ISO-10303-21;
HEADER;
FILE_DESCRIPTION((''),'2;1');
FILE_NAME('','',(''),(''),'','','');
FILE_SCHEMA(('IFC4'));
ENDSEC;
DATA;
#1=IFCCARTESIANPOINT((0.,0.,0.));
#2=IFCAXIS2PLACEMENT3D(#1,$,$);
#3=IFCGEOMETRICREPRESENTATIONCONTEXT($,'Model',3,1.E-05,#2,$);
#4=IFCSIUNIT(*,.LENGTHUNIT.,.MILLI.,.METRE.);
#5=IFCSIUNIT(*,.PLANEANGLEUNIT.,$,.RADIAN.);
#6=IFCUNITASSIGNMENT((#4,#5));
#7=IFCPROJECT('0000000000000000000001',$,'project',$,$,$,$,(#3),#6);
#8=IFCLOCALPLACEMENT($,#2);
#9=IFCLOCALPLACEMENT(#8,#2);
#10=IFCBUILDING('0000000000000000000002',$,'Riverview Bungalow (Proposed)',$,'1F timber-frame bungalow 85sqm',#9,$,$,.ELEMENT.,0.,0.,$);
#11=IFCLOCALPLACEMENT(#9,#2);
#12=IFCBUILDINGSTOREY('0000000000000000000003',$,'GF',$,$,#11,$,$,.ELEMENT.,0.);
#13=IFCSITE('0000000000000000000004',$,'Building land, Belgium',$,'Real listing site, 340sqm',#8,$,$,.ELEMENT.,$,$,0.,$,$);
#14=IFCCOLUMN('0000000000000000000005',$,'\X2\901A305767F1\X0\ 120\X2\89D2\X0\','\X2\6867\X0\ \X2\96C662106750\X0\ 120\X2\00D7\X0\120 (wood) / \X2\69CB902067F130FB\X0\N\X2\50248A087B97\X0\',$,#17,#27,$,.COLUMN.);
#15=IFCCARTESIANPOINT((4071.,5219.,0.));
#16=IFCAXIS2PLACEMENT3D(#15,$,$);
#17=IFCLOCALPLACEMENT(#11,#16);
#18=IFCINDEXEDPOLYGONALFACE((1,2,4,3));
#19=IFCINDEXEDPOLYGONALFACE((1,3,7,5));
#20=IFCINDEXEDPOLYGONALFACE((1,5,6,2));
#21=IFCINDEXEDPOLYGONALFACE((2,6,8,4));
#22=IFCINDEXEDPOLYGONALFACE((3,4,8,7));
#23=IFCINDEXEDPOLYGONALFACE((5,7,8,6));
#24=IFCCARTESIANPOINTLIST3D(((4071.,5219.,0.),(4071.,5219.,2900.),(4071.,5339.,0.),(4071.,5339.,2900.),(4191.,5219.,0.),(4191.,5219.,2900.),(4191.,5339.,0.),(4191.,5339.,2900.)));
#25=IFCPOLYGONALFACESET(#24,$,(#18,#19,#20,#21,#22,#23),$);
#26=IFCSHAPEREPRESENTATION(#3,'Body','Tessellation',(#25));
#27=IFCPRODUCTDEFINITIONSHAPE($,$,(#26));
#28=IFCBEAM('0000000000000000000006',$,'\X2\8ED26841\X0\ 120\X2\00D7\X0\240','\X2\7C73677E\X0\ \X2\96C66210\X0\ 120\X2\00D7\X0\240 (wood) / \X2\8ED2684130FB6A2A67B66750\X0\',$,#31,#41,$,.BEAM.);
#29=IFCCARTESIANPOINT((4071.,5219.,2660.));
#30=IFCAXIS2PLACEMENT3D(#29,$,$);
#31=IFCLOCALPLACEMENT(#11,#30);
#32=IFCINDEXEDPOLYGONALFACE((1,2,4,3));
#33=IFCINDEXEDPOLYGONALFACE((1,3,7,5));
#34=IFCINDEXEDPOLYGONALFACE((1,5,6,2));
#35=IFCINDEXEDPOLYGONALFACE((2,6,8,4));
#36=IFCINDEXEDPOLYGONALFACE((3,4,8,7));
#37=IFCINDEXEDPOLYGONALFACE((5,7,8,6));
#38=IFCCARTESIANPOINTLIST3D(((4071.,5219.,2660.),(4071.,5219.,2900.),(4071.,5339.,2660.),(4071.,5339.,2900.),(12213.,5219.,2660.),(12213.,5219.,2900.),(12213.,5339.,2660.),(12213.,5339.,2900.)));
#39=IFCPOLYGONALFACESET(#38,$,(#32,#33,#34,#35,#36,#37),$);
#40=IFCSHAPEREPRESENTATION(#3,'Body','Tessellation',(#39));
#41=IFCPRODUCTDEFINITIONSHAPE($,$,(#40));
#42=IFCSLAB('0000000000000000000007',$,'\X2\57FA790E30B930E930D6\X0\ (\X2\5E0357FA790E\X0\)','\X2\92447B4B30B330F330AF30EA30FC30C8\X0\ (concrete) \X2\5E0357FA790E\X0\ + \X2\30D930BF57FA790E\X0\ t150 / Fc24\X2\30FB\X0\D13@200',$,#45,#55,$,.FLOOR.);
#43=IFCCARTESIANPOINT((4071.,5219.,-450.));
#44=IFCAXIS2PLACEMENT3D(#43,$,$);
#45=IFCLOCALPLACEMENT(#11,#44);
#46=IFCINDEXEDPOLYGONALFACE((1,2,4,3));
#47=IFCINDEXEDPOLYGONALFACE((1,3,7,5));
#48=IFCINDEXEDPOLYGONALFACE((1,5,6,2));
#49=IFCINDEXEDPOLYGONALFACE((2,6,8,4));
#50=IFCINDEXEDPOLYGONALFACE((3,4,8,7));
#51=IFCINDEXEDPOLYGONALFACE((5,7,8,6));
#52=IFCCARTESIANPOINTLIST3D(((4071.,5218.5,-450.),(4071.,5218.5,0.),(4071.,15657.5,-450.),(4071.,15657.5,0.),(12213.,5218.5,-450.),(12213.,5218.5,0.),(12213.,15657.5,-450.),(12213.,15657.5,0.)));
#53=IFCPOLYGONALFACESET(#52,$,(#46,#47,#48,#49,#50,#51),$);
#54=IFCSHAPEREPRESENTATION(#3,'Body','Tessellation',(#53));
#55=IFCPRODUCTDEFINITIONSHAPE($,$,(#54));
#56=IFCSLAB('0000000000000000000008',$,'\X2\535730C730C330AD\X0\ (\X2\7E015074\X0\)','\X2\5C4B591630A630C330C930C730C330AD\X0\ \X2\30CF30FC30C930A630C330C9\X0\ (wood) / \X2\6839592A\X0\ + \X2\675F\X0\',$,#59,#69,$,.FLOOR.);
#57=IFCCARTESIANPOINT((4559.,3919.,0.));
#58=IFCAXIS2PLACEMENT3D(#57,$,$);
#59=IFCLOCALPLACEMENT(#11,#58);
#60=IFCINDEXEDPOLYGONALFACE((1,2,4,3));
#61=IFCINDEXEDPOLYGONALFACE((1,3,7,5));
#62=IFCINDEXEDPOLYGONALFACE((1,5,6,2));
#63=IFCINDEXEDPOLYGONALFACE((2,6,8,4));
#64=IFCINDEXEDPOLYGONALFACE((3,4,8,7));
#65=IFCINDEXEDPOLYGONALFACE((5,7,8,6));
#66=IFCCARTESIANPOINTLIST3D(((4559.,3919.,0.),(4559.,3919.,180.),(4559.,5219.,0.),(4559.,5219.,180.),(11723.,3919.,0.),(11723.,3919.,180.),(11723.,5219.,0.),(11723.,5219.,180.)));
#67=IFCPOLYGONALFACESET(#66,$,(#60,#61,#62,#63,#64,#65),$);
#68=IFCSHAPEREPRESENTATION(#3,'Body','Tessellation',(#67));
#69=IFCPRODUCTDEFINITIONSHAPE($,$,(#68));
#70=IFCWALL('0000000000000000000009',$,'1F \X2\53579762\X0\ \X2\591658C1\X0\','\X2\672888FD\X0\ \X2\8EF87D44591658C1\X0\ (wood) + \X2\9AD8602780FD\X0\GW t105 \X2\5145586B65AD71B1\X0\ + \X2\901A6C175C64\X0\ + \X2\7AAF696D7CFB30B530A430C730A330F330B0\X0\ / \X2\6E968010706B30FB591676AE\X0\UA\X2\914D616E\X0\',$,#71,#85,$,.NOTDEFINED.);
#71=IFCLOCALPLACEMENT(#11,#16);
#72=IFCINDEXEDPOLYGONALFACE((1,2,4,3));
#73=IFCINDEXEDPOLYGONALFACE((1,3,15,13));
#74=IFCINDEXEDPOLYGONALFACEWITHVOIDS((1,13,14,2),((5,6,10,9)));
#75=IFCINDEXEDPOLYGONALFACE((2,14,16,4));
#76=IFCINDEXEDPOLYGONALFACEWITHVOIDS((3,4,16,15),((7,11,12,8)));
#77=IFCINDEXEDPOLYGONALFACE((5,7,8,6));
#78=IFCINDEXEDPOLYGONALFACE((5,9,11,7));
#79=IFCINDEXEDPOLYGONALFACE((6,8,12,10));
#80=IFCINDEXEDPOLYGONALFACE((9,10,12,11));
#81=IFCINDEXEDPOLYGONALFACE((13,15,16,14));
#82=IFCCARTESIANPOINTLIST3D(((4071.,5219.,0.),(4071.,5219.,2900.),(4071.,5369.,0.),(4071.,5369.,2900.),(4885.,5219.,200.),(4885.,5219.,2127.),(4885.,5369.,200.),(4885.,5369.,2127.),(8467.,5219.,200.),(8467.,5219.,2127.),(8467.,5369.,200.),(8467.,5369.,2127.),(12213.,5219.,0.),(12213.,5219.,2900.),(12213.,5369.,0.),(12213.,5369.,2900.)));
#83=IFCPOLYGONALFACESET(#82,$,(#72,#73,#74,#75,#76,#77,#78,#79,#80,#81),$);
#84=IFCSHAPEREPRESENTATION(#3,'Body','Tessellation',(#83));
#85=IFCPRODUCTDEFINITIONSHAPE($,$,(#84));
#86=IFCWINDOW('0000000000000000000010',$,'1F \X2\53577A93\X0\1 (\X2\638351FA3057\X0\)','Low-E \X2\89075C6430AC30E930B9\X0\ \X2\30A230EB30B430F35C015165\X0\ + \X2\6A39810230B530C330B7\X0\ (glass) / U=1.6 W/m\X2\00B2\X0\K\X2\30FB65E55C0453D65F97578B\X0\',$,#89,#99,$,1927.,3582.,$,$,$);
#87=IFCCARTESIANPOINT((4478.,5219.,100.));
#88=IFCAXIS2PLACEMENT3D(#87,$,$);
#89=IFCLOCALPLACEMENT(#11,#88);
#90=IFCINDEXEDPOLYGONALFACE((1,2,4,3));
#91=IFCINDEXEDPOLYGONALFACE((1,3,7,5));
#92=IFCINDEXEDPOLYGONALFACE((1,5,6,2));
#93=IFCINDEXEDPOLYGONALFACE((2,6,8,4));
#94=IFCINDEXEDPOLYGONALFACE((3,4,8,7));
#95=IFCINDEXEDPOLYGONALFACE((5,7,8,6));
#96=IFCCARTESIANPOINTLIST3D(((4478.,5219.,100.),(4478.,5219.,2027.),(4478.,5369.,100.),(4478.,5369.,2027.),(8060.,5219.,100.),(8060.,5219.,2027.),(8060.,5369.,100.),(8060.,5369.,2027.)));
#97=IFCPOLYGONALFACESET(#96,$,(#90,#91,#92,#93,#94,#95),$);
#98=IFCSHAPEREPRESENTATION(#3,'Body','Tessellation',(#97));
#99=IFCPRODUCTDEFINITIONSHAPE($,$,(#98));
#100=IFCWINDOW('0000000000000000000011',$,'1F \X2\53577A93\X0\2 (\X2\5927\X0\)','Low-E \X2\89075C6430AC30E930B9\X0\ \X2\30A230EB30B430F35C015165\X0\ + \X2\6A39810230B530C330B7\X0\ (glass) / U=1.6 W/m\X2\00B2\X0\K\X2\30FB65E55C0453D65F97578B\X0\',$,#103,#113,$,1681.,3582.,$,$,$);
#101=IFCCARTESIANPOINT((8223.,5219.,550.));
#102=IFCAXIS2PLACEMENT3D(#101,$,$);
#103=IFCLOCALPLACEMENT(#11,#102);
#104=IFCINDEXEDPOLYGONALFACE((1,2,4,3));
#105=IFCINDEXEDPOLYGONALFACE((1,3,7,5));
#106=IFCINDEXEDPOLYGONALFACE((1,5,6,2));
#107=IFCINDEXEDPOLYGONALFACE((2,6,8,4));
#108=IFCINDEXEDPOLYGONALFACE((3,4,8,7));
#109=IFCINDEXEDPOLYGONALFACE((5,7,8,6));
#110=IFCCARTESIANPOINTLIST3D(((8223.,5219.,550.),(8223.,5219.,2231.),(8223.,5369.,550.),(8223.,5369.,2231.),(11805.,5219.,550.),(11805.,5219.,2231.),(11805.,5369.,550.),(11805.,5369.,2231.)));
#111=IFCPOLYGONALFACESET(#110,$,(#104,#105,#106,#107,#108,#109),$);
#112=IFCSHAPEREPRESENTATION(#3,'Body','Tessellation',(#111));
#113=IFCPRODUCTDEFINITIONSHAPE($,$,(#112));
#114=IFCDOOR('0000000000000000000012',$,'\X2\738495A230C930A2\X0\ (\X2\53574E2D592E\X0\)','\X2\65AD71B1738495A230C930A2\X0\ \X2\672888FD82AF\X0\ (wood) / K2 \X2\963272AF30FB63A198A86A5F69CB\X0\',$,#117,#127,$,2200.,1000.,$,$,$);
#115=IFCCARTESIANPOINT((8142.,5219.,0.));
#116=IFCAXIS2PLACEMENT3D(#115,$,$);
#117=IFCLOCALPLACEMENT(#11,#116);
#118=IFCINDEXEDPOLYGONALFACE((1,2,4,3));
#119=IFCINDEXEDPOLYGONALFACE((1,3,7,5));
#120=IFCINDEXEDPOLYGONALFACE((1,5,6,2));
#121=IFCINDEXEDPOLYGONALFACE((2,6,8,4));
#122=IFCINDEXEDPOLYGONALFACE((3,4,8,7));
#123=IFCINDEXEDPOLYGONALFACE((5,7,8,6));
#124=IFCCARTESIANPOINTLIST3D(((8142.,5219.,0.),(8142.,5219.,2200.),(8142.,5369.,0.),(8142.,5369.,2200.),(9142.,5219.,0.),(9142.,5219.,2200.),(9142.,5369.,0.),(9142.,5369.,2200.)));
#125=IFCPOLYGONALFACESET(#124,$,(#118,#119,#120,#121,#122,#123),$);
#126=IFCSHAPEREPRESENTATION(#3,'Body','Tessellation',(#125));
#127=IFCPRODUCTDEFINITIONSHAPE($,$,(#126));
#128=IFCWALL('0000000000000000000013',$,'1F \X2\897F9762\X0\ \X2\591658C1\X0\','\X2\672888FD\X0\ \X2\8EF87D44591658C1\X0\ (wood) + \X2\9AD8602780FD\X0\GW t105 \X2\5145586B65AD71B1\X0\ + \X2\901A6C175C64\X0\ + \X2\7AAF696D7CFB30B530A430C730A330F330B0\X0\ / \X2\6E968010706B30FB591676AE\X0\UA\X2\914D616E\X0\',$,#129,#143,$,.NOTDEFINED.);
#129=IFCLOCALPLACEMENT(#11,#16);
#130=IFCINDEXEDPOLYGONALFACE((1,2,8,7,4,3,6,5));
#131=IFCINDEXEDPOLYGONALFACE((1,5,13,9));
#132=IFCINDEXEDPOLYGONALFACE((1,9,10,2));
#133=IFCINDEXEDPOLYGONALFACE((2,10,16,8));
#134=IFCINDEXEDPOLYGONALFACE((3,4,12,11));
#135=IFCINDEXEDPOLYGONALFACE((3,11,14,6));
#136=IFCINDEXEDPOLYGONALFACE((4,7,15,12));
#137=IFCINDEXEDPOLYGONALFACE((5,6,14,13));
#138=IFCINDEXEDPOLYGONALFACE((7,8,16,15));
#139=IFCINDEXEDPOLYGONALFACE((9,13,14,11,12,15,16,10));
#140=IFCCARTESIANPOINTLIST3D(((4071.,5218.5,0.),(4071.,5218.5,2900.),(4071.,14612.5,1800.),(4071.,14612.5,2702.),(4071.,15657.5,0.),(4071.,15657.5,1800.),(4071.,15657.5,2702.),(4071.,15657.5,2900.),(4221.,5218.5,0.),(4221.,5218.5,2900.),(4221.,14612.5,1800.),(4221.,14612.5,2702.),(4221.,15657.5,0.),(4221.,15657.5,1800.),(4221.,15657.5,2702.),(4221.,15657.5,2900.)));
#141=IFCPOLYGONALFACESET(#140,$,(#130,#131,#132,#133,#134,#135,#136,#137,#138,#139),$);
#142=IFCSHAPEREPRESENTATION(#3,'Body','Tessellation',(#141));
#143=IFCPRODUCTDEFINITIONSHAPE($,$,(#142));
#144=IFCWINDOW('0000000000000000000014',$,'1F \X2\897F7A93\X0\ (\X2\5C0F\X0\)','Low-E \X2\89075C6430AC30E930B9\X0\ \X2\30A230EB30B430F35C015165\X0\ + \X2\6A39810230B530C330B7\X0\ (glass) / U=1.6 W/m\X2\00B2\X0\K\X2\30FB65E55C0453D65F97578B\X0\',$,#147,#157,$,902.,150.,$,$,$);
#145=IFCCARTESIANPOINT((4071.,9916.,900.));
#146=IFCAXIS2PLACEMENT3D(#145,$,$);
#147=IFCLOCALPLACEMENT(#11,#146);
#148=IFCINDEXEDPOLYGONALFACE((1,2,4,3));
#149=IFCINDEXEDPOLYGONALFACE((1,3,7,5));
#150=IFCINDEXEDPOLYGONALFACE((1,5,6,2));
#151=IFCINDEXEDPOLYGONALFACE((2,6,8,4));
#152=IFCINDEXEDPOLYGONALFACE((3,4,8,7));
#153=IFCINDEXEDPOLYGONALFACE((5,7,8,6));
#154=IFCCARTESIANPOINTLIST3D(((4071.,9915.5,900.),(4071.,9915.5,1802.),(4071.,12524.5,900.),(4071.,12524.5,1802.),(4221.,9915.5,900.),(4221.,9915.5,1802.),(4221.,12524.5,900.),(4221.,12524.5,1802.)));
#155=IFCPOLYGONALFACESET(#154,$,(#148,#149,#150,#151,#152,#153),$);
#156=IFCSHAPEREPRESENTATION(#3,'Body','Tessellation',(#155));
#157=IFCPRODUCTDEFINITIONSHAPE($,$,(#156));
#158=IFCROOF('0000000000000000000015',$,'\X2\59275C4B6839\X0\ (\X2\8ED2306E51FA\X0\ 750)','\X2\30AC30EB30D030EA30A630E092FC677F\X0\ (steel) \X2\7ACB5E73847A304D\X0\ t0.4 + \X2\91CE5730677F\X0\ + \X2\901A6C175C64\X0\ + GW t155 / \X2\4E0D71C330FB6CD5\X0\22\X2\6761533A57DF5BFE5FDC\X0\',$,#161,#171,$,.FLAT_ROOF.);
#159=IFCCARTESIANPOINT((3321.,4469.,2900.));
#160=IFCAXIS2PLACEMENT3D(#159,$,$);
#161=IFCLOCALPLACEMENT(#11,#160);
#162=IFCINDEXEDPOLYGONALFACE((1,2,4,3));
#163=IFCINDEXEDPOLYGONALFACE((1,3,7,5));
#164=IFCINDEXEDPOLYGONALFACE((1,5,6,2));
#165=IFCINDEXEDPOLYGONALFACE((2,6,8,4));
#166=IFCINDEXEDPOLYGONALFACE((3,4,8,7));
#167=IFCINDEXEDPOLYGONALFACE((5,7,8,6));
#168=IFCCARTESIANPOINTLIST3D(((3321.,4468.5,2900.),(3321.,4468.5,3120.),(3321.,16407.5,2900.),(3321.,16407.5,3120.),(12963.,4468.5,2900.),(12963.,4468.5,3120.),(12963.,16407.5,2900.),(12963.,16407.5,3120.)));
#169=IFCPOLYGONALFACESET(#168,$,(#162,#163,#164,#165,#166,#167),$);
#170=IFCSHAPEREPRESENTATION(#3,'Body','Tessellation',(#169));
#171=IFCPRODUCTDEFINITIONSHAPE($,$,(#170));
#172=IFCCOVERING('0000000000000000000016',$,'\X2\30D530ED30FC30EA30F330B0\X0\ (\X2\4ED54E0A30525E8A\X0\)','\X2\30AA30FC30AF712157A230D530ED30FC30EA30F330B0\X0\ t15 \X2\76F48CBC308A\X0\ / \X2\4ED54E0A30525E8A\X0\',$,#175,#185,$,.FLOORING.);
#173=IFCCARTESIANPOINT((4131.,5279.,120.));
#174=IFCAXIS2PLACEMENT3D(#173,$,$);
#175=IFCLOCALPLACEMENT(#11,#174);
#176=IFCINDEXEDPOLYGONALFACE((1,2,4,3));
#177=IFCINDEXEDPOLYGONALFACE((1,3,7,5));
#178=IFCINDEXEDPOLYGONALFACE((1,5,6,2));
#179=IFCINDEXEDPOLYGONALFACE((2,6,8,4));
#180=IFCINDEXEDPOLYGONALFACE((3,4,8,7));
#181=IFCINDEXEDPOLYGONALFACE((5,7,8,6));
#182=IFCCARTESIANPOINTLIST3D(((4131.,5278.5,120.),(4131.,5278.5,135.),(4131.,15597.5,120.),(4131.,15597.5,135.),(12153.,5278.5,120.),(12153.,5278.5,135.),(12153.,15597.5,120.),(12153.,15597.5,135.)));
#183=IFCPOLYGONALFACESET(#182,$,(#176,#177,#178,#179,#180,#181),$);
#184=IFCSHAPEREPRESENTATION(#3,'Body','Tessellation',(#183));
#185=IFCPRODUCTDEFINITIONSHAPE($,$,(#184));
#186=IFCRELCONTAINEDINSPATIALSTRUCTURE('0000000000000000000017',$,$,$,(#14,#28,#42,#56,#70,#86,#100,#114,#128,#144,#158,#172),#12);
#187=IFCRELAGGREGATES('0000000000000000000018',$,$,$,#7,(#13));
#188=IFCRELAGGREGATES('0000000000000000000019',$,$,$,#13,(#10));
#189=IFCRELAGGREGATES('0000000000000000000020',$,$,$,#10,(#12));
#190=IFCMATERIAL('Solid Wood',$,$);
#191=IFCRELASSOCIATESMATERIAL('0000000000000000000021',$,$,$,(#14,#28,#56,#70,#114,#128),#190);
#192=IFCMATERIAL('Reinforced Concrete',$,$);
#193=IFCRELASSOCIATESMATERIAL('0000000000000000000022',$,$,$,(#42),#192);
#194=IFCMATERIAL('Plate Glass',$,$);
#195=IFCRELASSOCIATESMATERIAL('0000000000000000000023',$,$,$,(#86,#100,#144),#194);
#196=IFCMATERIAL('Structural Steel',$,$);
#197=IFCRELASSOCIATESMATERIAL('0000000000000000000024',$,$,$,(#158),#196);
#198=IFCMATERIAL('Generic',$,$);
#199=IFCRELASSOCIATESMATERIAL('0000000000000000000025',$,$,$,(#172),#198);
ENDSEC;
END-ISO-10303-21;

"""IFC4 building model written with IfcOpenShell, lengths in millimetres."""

from ifc_helpers import new_model, si_unit, frame, frame_2d, origin, place, context, project, spatial, rectangle, extrude, material, element, fill, save


model = new_model("IFC4")

# Units and contexts
model_context = context("Model", 3, precision=1e-05, world=origin())
ifc_project = project(units=[si_unit("LENGTHUNIT", "METRE", prefix="MILLI"), si_unit("PLANEANGLEUNIT", "RADIAN")], contexts=[model_context])

# Site, building, storey
site_placement = place(None, origin())
site = spatial("IfcSite", under=ifc_project, at=site_placement, Name="Building land, Belgium", ObjectType="Real listing site, 340sqm", CompositionType="ELEMENT", RefElevation=0.0)
building_placement = place(site_placement, origin())
building = spatial("IfcBuilding", under=site, at=building_placement, Name="Riverview Bungalow (Proposed)", ObjectType="1F timber-frame bungalow 85sqm", CompositionType="ELEMENT", ElevationOfRefHeight=0.0, ElevationOfTerrain=0.0)
storey_placement = place(building_placement, origin())
storey = spatial("IfcBuildingStorey", under=building, at=storey_placement, Name="GF", CompositionType="ELEMENT", Elevation=0.0)

# Column
ifc_material_1 = material(Name="Solid Wood")
column_1_placement = place(storey_placement, frame((4071.0, 5219.0, 0.0)))
element("IfcColumn", 1, at=column_1_placement, inside=storey, material=ifc_material_1, Name="通し柱 120角", Description="桧 集成材 120×120 (wood) / 構造柱・N値計算", PredefinedType="COLUMN", context=model_context, shape_type="SweptSolid", body=[
    extrude(rectangle(XDim=120.0, YDim=120.0, at=frame_2d((60.0, 60.0))), frame((4071.0, 5219.0, 0.0)), (0.0, 0.0, 1.0), 2900.0),
])

# Beam
beam_1_placement = place(storey_placement, frame((4071.0, 5219.0, 2660.0)))
element("IfcBeam", 2, at=beam_1_placement, inside=storey, material=ifc_material_1, Name="軒桁 120×240", Description="米松 集成 120×240 (wood) / 軒桁・横架材", PredefinedType="BEAM", context=model_context, shape_type="SweptSolid", body=[
    extrude(rectangle(XDim=8142.0, YDim=120.0, at=frame_2d((4071.0, 60.0))), frame((4071.0, 5219.0, 2660.0)), (0.0, 0.0, 1.0), 240.0),
])

# Slabs
ifc_material_2 = material(Name="Reinforced Concrete")
slab_1_placement = place(storey_placement, frame((4071.0, 5219.0, -450.0)))
element("IfcSlab", 3, at=slab_1_placement, inside=storey, material=ifc_material_2, Name="基礎スラブ (布基礎)", Description="鉄筋コンクリート (concrete) 布基礎 + ベタ基礎 t150 / Fc24・D13@200", PredefinedType="FLOOR", context=model_context, shape_type="SweptSolid", body=[
    extrude(rectangle(XDim=8142.0, YDim=10439.0, at=frame_2d((4071.0, 5219.0))), frame((4071.0, 5219.0, -450.0)), (0.0, 0.0, 1.0), 450.0),
])
slab_2_placement = place(storey_placement, frame((4559.0, 3919.0, 0.0)))
element("IfcSlab", 4, at=slab_2_placement, inside=storey, material=ifc_material_1, Name="南デッキ (縁側)", Description="屋外ウッドデッキ ハードウッド (wood) / 根太 + 束", PredefinedType="FLOOR", context=model_context, shape_type="SweptSolid", body=[
    extrude(rectangle(XDim=7164.0, YDim=1300.0, at=frame_2d((3582.0, 650.0))), frame((4559.0, 3919.0, 0.0)), (0.0, 0.0, 1.0), 180.0),
])

# Wall, openings, windows, door
wall_1_placement = place(storey_placement, frame((4071.0, 5219.0, 0.0)))
wall_1 = element("IfcWall", 5, at=wall_1_placement, inside=storey, material=ifc_material_1, Name="1F 南面 外壁", Description="木製 軸組外壁 (wood) + 高性能GW t105 充填断熱 + 通気層 + 窯業系サイディング / 準耐火・外皮UA配慮", PredefinedType="NOTDEFINED", context=model_context, shape_type="SweptSolid", body=[
    extrude(rectangle(XDim=8142.0, YDim=150.0, at=frame_2d((4071.0, 75.0))), frame((4071.0, 5219.0, 0.0)), (0.0, 0.0, 1.0), 2900.0),
])
opening_1_placement = place(storey_placement, frame((4478.0, 5219.0, 100.0)))
opening_1 = element("IfcOpeningElement", 6, at=opening_1_placement, cuts=wall_1, PredefinedType="NOTDEFINED", context=model_context, shape_type="SweptSolid", body=[
    extrude(rectangle(XDim=3582.0, YDim=150.0, at=frame_2d((1791.0, 75.0))), frame((4478.0, 5219.0, 100.0)), (0.0, 0.0, 1.0), 1927.0),
])
opening_2_placement = place(storey_placement, frame((8223.0, 5219.0, 550.0)))
opening_2 = element("IfcOpeningElement", 7, at=opening_2_placement, cuts=wall_1, PredefinedType="NOTDEFINED", context=model_context, shape_type="SweptSolid", body=[
    extrude(rectangle(XDim=3582.0, YDim=150.0, at=frame_2d((1791.0, 75.0))), frame((8223.0, 5219.0, 550.0)), (0.0, 0.0, 1.0), 1681.0),
])
opening_3_placement = place(storey_placement, frame((8142.0, 5219.0, 0.0)))
opening_3 = element("IfcOpeningElement", 8, at=opening_3_placement, cuts=wall_1, PredefinedType="NOTDEFINED", context=model_context, shape_type="SweptSolid", body=[
    extrude(rectangle(XDim=1000.0, YDim=150.0, at=frame_2d((500.0, 75.0))), frame((8142.0, 5219.0, 0.0)), (0.0, 0.0, 1.0), 2200.0),
])
ifc_material_3 = material(Name="Plate Glass")
window_1_placement = place(storey_placement, frame((4478.0, 5219.0, 100.0)))
window_1 = element("IfcWindow", 9, at=window_1_placement, inside=storey, material=ifc_material_3, Name="1F 南窓1 (掃出し)", Description="Low-E 複層ガラス アルゴン封入 + 樹脂サッシ (glass) / U=1.6 W/m²K・日射取得型", OverallHeight=1927.0, OverallWidth=3582.0, context=model_context, shape_type="SweptSolid", body=[
    extrude(rectangle(XDim=3582.0, YDim=150.0, at=frame_2d((1791.0, 75.0))), frame((4478.0, 5219.0, 100.0)), (0.0, 0.0, 1.0), 1927.0),
])
fill(opening_1, window_1)
window_2_placement = place(storey_placement, frame((8223.0, 5219.0, 550.0)))
window_2 = element("IfcWindow", 10, at=window_2_placement, inside=storey, material=ifc_material_3, Name="1F 南窓2 (大)", Description="Low-E 複層ガラス アルゴン封入 + 樹脂サッシ (glass) / U=1.6 W/m²K・日射取得型", OverallHeight=1681.0, OverallWidth=3582.0, context=model_context, shape_type="SweptSolid", body=[
    extrude(rectangle(XDim=3582.0, YDim=150.0, at=frame_2d((1791.0, 75.0))), frame((8223.0, 5219.0, 550.0)), (0.0, 0.0, 1.0), 1681.0),
])
fill(opening_2, window_2)
door_placement = place(storey_placement, frame((8142.0, 5219.0, 0.0)))
door = element("IfcDoor", 11, at=door_placement, inside=storey, material=ifc_material_1, Name="玄関ドア (南中央)", Description="断熱玄関ドア 木製芯 (wood) / K2 防犯・採風機構", OverallHeight=2200.0, OverallWidth=1000.0, context=model_context, shape_type="SweptSolid", body=[
    extrude(rectangle(XDim=1000.0, YDim=150.0, at=frame_2d((500.0, 75.0))), frame((8142.0, 5219.0, 0.0)), (0.0, 0.0, 1.0), 2200.0),
])
fill(opening_3, door)

# Wall, opening, window
wall_2_placement = place(storey_placement, frame((4071.0, 5219.0, 0.0)))
wall_2 = element("IfcWall", 12, at=wall_2_placement, inside=storey, material=ifc_material_1, Name="1F 西面 外壁", Description="木製 軸組外壁 (wood) + 高性能GW t105 充填断熱 + 通気層 + 窯業系サイディング / 準耐火・外皮UA配慮", PredefinedType="NOTDEFINED", context=model_context, shape_type="SweptSolid", body=[
    extrude(rectangle(XDim=150.0, YDim=10439.0, at=frame_2d((75.0, 5219.0))), frame((4071.0, 5219.0, 0.0)), (0.0, 0.0, 1.0), 2900.0),
])
opening_4_placement = place(storey_placement, frame((4071.0, 9916.0, 900.0)))
opening_4 = element("IfcOpeningElement", 13, at=opening_4_placement, cuts=wall_2, PredefinedType="NOTDEFINED", context=model_context, shape_type="SweptSolid", body=[
    extrude(rectangle(XDim=150.0, YDim=2609.0, at=frame_2d((75.0, 1304.0))), frame((4071.0, 9916.0, 900.0)), (0.0, 0.0, 1.0), 902.0),
])
window_3_placement = place(storey_placement, frame((4071.0, 9916.0, 900.0)))
window_3 = element("IfcWindow", 14, at=window_3_placement, inside=storey, material=ifc_material_3, Name="1F 西窓 (小)", Description="Low-E 複層ガラス アルゴン封入 + 樹脂サッシ (glass) / U=1.6 W/m²K・日射取得型", OverallHeight=902.0, OverallWidth=150.0, context=model_context, shape_type="SweptSolid", body=[
    extrude(rectangle(XDim=150.0, YDim=2609.0, at=frame_2d((75.0, 1304.0))), frame((4071.0, 9916.0, 900.0)), (0.0, 0.0, 1.0), 902.0),
])
fill(opening_4, window_3)

# Roof
ifc_material_4 = material(Name="Structural Steel")
roof_placement = place(storey_placement, frame((3321.0, 4469.0, 2900.0)))
element("IfcRoof", 15, at=roof_placement, inside=storey, material=ifc_material_4, Name="大屋根 (軒の出 750)", Description="ガルバリウム鋼板 (steel) 立平葺き t0.4 + 野地板 + 通気層 + GW t155 / 不燃・法22条区域対応", PredefinedType="FLAT_ROOF", context=model_context, shape_type="SweptSolid", body=[
    extrude(rectangle(XDim=9642.0, YDim=11939.0, at=frame_2d((4821.0, 5969.0))), frame((3321.0, 4469.0, 2900.0)), (0.0, 0.0, 1.0), 220.0),
])

# Covering
ifc_material_5 = material(Name="Generic")
covering_1_placement = place(storey_placement, frame((4131.0, 5279.0, 120.0)))
element("IfcCovering", 16, at=covering_1_placement, inside=storey, material=ifc_material_5, Name="フローリング (仕上げ床)", Description="オーク無垢フローリング t15 直貼り / 仕上げ床", PredefinedType="FLOORING", context=model_context, shape_type="SweptSolid", body=[
    extrude(rectangle(XDim=8022.0, YDim=10319.0, at=frame_2d((4011.0, 5159.0))), frame((4131.0, 5279.0, 120.0)), (0.0, 0.0, 1.0), 15.0),
])

save(model, "model.ifc")
